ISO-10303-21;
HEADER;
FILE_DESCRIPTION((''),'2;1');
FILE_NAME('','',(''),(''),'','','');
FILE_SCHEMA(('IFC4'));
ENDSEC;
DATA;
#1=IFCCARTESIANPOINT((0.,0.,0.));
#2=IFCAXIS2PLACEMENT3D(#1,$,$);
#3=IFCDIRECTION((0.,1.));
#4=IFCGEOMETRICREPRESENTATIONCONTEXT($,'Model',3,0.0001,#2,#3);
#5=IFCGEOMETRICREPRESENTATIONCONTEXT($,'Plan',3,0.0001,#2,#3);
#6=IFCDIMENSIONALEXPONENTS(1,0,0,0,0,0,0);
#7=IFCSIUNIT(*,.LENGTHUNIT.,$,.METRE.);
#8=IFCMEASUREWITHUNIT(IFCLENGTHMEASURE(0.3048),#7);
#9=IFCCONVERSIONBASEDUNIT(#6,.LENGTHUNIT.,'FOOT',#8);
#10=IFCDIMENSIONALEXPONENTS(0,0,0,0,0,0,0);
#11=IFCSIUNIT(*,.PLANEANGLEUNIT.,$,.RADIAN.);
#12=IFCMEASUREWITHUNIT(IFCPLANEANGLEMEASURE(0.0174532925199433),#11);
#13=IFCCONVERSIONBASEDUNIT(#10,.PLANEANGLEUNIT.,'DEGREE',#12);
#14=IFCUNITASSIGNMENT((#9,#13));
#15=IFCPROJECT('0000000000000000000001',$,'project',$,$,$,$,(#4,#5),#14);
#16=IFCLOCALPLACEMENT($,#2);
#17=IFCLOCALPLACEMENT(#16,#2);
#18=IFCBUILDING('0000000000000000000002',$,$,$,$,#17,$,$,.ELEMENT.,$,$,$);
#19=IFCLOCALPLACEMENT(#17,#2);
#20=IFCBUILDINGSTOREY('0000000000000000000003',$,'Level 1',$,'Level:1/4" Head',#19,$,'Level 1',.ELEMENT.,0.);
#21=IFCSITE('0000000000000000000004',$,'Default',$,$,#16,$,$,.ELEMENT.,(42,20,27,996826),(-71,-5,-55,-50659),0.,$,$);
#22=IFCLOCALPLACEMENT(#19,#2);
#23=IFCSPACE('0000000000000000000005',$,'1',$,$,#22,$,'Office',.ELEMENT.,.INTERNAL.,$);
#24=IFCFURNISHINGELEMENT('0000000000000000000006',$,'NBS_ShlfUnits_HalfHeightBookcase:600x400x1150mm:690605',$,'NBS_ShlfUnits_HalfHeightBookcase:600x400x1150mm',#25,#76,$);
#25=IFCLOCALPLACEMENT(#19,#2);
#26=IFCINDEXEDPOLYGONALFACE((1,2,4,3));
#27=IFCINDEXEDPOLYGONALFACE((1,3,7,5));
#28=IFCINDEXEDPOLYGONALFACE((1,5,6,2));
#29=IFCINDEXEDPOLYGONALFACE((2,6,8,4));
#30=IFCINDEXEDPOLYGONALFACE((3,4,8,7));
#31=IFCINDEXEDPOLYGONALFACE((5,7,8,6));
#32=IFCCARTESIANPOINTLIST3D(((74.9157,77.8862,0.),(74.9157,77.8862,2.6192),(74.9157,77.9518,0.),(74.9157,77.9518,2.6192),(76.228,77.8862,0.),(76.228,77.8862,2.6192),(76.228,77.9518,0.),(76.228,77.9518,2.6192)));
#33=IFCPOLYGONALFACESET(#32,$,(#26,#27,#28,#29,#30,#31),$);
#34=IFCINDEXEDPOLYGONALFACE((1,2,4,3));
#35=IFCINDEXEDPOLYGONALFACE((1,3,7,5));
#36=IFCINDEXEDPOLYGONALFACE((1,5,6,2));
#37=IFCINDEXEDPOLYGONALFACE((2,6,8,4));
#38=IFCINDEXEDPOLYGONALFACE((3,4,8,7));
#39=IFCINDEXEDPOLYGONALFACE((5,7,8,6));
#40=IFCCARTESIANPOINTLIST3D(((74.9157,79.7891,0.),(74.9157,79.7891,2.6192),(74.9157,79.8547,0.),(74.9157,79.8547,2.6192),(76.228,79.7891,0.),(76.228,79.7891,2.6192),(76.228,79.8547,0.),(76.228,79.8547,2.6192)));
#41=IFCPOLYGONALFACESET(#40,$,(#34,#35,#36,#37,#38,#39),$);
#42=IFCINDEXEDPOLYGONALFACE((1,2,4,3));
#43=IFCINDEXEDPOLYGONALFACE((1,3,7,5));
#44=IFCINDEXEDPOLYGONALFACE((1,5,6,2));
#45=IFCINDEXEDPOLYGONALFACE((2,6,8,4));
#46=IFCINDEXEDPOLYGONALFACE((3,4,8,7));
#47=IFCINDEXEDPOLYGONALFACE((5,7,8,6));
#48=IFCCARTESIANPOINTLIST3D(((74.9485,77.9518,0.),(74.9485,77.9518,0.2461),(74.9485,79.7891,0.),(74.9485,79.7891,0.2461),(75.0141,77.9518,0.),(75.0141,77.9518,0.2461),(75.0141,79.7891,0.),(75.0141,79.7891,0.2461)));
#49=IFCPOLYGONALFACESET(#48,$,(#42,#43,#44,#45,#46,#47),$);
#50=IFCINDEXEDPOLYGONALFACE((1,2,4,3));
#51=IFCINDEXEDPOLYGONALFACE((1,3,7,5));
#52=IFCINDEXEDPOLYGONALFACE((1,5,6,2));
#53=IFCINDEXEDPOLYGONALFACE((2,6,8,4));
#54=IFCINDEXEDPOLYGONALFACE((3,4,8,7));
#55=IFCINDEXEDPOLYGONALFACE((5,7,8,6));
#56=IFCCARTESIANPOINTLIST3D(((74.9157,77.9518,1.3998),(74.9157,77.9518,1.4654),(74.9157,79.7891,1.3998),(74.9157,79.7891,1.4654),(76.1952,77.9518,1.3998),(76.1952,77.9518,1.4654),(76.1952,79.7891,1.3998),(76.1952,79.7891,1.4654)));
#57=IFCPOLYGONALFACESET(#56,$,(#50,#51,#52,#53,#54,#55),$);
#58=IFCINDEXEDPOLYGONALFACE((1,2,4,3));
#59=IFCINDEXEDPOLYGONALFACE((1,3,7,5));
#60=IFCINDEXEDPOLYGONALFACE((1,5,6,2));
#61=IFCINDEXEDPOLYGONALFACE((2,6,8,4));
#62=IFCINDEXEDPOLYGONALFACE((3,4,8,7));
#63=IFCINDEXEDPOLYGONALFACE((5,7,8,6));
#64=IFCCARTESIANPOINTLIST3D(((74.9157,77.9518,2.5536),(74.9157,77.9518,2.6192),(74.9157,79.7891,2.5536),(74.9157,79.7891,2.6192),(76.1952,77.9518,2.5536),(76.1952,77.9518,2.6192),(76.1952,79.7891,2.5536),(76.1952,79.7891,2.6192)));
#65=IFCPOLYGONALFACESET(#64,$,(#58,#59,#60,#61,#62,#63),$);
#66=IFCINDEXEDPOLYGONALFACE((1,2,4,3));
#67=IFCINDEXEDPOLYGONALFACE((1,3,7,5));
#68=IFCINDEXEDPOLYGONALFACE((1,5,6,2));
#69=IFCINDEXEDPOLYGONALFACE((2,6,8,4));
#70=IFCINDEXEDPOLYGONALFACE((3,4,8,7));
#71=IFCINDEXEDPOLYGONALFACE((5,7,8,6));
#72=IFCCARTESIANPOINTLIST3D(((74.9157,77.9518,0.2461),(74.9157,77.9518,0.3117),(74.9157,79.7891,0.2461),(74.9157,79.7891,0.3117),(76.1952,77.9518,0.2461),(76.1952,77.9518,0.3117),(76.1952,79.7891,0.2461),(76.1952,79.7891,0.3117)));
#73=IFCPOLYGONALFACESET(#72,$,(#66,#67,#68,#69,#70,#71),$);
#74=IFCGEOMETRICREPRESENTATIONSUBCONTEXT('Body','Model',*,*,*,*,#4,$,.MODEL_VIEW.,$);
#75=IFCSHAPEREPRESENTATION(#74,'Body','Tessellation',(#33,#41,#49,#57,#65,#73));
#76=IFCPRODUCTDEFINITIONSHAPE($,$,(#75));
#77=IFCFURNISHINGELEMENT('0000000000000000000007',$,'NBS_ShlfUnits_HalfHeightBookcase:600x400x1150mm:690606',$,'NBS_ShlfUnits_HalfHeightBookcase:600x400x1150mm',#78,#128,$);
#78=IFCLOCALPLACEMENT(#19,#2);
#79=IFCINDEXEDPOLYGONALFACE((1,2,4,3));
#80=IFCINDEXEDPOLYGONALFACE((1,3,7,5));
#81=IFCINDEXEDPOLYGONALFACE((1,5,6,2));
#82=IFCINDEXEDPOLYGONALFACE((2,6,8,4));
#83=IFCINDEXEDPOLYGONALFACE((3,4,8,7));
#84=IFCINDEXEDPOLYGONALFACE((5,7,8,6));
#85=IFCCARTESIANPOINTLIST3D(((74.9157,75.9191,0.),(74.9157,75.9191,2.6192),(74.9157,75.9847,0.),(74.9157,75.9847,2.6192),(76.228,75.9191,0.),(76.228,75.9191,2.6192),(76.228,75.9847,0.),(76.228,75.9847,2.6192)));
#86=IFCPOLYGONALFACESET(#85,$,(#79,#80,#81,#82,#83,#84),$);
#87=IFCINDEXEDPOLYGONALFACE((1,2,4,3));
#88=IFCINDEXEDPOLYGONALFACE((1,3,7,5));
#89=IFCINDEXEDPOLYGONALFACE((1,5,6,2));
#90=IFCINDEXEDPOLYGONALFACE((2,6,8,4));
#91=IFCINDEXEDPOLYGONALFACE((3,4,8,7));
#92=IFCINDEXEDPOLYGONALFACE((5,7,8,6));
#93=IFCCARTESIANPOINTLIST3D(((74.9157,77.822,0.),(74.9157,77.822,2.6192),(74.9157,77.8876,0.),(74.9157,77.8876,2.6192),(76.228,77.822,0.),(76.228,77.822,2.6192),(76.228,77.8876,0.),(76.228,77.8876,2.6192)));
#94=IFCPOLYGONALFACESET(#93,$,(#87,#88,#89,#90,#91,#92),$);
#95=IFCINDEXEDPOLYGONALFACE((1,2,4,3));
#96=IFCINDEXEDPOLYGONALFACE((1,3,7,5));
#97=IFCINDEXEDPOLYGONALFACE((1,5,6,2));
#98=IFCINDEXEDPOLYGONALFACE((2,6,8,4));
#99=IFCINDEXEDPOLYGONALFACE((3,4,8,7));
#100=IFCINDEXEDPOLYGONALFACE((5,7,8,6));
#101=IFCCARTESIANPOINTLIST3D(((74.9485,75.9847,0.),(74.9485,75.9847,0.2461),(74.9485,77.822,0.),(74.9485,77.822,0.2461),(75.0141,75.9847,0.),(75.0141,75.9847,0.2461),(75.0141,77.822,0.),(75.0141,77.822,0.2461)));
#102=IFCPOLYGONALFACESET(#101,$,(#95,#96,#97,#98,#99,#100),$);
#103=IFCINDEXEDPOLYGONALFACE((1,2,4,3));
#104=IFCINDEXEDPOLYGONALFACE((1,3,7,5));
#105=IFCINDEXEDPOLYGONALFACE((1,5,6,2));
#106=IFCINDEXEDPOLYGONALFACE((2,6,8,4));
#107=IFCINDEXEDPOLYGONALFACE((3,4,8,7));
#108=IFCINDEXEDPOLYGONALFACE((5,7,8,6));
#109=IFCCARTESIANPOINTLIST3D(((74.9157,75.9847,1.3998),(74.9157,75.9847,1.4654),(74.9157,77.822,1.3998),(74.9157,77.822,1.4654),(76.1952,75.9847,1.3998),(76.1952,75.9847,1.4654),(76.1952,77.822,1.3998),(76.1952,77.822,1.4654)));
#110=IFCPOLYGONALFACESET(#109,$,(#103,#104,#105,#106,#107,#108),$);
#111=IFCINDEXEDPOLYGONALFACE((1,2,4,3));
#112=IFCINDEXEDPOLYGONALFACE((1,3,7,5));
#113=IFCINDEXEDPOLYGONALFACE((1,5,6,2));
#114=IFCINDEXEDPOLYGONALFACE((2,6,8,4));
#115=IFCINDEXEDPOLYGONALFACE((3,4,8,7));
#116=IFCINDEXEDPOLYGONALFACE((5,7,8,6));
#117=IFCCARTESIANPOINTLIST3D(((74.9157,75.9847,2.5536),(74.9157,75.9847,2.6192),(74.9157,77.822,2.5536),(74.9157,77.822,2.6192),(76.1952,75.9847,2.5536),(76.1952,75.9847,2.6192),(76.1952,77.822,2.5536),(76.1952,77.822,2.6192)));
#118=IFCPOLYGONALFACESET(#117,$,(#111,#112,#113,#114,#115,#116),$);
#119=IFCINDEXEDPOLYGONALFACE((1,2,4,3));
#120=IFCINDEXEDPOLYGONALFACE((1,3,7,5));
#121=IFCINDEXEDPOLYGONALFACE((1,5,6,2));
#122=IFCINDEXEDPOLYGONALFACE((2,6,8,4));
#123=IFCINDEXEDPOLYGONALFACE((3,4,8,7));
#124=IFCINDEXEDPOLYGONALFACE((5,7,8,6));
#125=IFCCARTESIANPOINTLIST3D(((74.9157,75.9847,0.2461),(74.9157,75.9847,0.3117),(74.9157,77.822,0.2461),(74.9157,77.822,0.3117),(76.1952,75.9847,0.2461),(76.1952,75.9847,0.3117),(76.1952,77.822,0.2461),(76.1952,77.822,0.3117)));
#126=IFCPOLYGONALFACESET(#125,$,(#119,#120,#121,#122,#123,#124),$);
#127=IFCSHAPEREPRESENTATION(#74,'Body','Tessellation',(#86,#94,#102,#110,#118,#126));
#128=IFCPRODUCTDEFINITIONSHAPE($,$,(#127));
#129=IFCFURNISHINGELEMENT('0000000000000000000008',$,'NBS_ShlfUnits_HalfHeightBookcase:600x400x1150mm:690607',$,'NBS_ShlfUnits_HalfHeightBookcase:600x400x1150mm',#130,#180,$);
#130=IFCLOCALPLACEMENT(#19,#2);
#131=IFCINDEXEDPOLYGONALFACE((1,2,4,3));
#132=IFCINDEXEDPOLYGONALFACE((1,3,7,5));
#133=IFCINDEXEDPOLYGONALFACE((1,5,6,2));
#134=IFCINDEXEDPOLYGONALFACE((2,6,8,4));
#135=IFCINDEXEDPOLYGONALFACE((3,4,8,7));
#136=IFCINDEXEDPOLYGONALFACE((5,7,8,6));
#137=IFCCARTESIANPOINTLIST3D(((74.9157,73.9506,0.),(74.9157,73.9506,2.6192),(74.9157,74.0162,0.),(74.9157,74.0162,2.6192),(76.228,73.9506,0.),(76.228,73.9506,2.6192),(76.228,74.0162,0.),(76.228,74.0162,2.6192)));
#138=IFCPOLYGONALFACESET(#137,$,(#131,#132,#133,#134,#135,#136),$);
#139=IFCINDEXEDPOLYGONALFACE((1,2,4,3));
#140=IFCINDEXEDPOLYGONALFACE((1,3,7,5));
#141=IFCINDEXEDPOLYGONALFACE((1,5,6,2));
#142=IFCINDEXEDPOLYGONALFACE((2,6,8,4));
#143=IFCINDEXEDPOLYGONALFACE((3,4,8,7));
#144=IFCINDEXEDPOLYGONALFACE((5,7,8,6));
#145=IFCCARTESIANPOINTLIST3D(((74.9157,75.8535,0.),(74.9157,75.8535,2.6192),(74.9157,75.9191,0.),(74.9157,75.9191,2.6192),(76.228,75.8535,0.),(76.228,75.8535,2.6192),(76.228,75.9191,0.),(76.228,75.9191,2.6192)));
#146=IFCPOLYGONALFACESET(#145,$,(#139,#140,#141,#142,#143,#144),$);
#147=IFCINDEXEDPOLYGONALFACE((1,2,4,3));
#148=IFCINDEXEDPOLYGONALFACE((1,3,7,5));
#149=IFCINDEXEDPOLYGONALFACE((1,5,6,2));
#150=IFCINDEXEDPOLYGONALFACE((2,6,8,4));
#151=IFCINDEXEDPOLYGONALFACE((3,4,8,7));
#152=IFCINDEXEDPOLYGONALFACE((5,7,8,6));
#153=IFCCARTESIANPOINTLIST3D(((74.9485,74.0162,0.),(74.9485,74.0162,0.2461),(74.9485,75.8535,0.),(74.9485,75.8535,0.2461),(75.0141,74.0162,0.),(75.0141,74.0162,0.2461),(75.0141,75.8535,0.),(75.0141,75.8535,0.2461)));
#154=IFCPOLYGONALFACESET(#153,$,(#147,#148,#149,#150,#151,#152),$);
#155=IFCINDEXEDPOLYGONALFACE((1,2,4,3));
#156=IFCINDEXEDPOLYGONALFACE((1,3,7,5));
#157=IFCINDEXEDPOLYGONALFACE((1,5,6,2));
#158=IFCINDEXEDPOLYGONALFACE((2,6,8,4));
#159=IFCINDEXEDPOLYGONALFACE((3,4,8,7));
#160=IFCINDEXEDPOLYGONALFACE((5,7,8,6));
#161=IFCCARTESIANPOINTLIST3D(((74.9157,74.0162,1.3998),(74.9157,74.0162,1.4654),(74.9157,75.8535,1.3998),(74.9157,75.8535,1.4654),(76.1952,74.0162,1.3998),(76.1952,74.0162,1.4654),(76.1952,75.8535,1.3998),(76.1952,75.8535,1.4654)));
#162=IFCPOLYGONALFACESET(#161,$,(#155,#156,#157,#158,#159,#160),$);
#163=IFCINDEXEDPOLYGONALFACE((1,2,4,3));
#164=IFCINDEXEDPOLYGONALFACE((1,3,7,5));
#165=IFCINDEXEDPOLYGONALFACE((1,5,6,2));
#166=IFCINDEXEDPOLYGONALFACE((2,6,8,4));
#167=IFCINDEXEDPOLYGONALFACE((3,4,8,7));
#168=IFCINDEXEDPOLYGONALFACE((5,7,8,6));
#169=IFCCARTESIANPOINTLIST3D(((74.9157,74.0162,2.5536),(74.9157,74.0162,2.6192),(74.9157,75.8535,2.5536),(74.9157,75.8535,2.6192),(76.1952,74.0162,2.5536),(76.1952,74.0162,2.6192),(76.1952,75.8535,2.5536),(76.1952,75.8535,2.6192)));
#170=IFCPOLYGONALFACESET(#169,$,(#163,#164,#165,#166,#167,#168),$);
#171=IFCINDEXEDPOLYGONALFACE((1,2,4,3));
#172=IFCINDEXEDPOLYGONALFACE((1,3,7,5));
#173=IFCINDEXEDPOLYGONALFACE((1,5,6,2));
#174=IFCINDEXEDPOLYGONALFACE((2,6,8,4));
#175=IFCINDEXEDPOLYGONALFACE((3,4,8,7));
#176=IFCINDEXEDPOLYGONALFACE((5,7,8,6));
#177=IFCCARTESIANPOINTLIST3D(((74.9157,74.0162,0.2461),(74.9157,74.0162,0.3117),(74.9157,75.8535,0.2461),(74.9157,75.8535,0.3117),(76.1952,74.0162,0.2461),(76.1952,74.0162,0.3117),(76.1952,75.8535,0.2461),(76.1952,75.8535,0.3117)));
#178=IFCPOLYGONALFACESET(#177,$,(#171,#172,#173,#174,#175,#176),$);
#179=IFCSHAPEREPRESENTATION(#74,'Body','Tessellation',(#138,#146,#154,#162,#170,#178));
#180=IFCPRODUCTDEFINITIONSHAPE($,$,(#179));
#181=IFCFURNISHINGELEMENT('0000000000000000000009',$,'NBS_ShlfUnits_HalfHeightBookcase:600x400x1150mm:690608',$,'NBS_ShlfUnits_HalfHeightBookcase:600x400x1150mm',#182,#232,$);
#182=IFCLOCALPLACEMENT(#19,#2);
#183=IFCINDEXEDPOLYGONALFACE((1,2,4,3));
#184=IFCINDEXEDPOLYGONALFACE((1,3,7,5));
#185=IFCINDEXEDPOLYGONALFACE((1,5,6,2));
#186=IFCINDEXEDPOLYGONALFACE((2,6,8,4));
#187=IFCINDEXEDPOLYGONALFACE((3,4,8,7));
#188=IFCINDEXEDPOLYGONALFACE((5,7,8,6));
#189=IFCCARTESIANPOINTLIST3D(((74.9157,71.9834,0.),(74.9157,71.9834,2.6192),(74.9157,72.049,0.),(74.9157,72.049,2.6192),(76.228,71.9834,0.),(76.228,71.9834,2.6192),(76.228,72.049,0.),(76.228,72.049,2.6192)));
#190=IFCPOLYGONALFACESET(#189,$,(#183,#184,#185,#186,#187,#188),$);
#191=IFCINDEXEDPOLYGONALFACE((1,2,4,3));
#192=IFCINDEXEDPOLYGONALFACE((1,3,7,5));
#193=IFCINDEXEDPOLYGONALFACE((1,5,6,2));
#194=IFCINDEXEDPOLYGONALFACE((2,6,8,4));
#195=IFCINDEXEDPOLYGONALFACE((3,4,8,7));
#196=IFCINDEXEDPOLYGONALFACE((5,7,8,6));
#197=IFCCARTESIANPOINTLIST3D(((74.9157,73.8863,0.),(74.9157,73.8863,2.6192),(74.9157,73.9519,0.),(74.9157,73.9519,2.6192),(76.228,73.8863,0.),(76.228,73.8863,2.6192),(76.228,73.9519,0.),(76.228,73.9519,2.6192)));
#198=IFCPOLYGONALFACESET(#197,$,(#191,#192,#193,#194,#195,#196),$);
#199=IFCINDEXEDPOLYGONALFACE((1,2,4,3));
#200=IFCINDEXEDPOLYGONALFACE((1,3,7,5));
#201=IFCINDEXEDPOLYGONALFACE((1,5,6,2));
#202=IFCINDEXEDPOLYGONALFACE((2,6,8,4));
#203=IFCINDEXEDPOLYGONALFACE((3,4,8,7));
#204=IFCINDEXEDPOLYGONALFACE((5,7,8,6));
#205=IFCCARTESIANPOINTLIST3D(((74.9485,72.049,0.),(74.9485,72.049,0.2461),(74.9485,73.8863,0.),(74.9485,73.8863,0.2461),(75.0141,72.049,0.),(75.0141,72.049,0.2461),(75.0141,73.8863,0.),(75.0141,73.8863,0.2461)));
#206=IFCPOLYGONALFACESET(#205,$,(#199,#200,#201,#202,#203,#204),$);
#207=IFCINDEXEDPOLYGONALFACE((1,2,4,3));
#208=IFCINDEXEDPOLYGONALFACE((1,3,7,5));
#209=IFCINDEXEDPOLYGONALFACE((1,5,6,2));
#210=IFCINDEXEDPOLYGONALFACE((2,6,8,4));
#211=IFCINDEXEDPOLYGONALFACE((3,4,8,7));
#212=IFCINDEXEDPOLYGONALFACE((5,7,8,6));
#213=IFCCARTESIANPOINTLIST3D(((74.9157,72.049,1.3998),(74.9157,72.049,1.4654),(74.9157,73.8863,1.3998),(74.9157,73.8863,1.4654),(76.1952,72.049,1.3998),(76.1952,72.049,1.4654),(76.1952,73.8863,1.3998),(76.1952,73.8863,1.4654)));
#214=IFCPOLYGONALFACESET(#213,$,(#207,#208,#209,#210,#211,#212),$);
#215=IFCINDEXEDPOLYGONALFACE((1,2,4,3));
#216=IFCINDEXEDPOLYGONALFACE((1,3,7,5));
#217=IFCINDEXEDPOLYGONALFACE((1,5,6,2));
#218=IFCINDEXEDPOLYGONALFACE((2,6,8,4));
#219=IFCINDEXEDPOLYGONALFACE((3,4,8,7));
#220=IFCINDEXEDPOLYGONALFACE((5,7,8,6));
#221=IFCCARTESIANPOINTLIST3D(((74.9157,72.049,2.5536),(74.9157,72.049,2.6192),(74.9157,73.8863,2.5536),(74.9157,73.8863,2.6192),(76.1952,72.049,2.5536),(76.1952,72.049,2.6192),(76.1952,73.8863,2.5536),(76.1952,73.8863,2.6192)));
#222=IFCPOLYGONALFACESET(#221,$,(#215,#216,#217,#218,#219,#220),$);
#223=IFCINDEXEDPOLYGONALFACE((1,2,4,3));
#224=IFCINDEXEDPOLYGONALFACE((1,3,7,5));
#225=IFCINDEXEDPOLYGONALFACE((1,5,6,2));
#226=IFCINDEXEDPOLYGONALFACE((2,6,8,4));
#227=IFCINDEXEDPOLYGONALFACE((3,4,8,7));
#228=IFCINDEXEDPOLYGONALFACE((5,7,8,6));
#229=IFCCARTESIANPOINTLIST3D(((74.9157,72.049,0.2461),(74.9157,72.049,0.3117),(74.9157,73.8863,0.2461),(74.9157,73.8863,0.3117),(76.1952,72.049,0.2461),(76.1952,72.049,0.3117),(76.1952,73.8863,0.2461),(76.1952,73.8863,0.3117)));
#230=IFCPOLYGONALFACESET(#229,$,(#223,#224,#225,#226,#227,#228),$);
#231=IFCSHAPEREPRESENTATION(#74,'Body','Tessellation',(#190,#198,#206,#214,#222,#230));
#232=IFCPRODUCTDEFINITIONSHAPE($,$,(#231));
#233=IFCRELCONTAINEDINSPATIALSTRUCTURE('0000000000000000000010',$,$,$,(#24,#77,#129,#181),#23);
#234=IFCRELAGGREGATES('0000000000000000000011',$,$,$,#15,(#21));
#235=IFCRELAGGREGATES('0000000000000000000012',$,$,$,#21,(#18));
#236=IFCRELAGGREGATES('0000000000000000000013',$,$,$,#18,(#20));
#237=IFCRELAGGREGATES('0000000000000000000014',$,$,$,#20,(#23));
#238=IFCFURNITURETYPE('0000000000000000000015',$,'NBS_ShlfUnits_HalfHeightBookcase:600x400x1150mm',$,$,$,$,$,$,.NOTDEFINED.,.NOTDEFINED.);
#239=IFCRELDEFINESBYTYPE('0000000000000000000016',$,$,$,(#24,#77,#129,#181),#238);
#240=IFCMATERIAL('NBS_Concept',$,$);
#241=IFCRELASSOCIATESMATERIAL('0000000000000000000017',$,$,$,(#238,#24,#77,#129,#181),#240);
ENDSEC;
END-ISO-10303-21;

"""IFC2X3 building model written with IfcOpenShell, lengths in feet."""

from ifc_helpers import new_model, entity, si_unit, converted_unit, direction, frame, frame_2d, origin, origin_2d_with_axis, place, context, subcontext, project, spatial, rectangle, extrude, source, transform, mapped, material, type_object, type_shapes, element, save


model = new_model("IFC2X3")

# Units and contexts
model_context = context("Model", 3, precision=0.0001, world=origin(), true_north=direction((0.0, 1.0)))
plan_context = context("Plan", 3, precision=0.0001, world=origin(), true_north=direction((0.0, 1.0)))
body_context = subcontext(model_context, "Body", "Model", "MODEL_VIEW")
ifc_project = project(units=[converted_unit("LENGTHUNIT", "FOOT", entity("IfcLengthMeasure", 0.3048), si_unit("LENGTHUNIT", "METRE"), dimensions=[1, 0, 0, 0, 0, 0, 0]), converted_unit("PLANEANGLEUNIT", "DEGREE", entity("IfcPlaneAngleMeasure", 0.0174532925199433), si_unit("PLANEANGLEUNIT", "RADIAN"), dimensions=[0, 0, 0, 0, 0, 0, 0])], contexts=[model_context, plan_context])

# Site, building, storey
site_placement = place(None, origin())
site = spatial("IfcSite", under=ifc_project, at=site_placement, Name="Default", CompositionType="ELEMENT", RefLatitude=(42, 20, 27, 996826), RefLongitude=(-71, -5, -55, -50659), RefElevation=0.0)
building_placement = place(site_placement, origin())
building = spatial("IfcBuilding", under=site, at=building_placement, CompositionType="ELEMENT")
storey_placement = place(building_placement, origin())
storey = spatial("IfcBuildingStorey", under=building, at=storey_placement, Name="Level 1", ObjectType="Level:1/4\" Head", LongName="Level 1", CompositionType="ELEMENT", Elevation=0.0)

# Shared definitions
space_1_placement = place(storey_placement, origin())
space_1 = spatial("IfcSpace", under=storey, at=space_1_placement, Name="1", LongName="Office", CompositionType="ELEMENT", InteriorOrExteriorSpace="INTERNAL")

# Furnishing elements
ifc_material_1 = material(Name="NBS_Concept")
furniture_type_1 = type_object("IfcFurnitureType", Name="NBS_ShlfUnits_HalfHeightBookcase:600x400x1150mm", AssemblyPlace="NOTDEFINED", material=ifc_material_1)
shared_shape_1 = source(origin(), body_context, "Body", "SweptSolid", [
    extrude(rectangle(XDim=0.0656, YDim=1.3123, at=origin_2d_with_axis()), frame((0.9514, -0.6562, 0.0), z_axis=(0.0, 0.0, 1.0), x_axis=(-1.0, 0.0, 0.0)), (0.0, 0.0, 1.0), 2.6192),
    extrude(rectangle(XDim=0.0656, YDim=1.3123, at=origin_2d_with_axis()), frame((-0.9514, -0.6562, 0.0), z_axis=(0.0, 0.0, 1.0), x_axis=(-1.0, 0.0, 0.0)), (0.0, 0.0, 1.0), 2.6192),
    extrude(rectangle(XDim=1.8373, YDim=0.0656, at=origin_2d_with_axis()), frame((0.0, -1.2467, 0.0), z_axis=(0.0, 0.0, 1.0), x_axis=(-1.0, 0.0, 0.0)), (0.0, 0.0, 1.0), 0.2461),
    extrude(rectangle(XDim=1.2795, YDim=1.8373, at=frame_2d((0.0, 0.0), x_axis=(1.0, 0.0))), frame((0.0, -0.6726, 1.3998), z_axis=(0.0, 0.0, 1.0), x_axis=(0.0, 1.0, 0.0)), (0.0, 0.0, 1.0), 0.0656),
    extrude(rectangle(XDim=1.2795, YDim=1.8373, at=frame_2d((0.0, 0.0), x_axis=(1.0, 0.0))), frame((0.0, -0.6726, 2.5536), z_axis=(0.0, 0.0, 1.0), x_axis=(0.0, 1.0, 0.0)), (0.0, 0.0, 1.0), 0.0656),
    extrude(rectangle(XDim=1.2795, YDim=1.8373, at=frame_2d((0.0, 0.0), x_axis=(1.0, 0.0))), frame((0.0, -0.6726, 0.2461), z_axis=(0.0, 0.0, 1.0), x_axis=(0.0, 1.0, 0.0)), (0.0, 0.0, 1.0), 0.0656),
])
type_shapes(furniture_type_1, [shared_shape_1])
for number, where, z_axis, x_axis, name in (
    (1, (76.228, 78.8705, 0.0), (0.0, 0.0, 1.0), (0.0, -1.0, 0.0), "NBS_ShlfUnits_HalfHeightBookcase:600x400x1150mm:690605"),
    (2, (76.228, 76.9033, 0.0), (0.0, 0.0, 1.0), (0.0, -1.0, 0.0), "NBS_ShlfUnits_HalfHeightBookcase:600x400x1150mm:690606"),
    (3, (76.228, 74.9348, 0.0), (0.0, 0.0, 1.0), (0.0, -1.0, 0.0), "NBS_ShlfUnits_HalfHeightBookcase:600x400x1150mm:690607"),
    (4, (76.228, 72.9677, 0.0), (0.0, 0.0, 1.0), (0.0, -1.0, 0.0), "NBS_ShlfUnits_HalfHeightBookcase:600x400x1150mm:690608"),
):
    element("IfcFurnishingElement", number, at=place(space_1_placement, frame(where, z_axis=z_axis, x_axis=x_axis)), inside=space_1, type_object=furniture_type_1, material=ifc_material_1, Name=name, ObjectType="NBS_ShlfUnits_HalfHeightBookcase:600x400x1150mm", context=body_context, shape_type="MappedRepresentation", body=[
        mapped(shared_shape_1, transform((0.0, 0.0, 0.0), scale=1.0)),
    ])

save(model, "model.ifc")
